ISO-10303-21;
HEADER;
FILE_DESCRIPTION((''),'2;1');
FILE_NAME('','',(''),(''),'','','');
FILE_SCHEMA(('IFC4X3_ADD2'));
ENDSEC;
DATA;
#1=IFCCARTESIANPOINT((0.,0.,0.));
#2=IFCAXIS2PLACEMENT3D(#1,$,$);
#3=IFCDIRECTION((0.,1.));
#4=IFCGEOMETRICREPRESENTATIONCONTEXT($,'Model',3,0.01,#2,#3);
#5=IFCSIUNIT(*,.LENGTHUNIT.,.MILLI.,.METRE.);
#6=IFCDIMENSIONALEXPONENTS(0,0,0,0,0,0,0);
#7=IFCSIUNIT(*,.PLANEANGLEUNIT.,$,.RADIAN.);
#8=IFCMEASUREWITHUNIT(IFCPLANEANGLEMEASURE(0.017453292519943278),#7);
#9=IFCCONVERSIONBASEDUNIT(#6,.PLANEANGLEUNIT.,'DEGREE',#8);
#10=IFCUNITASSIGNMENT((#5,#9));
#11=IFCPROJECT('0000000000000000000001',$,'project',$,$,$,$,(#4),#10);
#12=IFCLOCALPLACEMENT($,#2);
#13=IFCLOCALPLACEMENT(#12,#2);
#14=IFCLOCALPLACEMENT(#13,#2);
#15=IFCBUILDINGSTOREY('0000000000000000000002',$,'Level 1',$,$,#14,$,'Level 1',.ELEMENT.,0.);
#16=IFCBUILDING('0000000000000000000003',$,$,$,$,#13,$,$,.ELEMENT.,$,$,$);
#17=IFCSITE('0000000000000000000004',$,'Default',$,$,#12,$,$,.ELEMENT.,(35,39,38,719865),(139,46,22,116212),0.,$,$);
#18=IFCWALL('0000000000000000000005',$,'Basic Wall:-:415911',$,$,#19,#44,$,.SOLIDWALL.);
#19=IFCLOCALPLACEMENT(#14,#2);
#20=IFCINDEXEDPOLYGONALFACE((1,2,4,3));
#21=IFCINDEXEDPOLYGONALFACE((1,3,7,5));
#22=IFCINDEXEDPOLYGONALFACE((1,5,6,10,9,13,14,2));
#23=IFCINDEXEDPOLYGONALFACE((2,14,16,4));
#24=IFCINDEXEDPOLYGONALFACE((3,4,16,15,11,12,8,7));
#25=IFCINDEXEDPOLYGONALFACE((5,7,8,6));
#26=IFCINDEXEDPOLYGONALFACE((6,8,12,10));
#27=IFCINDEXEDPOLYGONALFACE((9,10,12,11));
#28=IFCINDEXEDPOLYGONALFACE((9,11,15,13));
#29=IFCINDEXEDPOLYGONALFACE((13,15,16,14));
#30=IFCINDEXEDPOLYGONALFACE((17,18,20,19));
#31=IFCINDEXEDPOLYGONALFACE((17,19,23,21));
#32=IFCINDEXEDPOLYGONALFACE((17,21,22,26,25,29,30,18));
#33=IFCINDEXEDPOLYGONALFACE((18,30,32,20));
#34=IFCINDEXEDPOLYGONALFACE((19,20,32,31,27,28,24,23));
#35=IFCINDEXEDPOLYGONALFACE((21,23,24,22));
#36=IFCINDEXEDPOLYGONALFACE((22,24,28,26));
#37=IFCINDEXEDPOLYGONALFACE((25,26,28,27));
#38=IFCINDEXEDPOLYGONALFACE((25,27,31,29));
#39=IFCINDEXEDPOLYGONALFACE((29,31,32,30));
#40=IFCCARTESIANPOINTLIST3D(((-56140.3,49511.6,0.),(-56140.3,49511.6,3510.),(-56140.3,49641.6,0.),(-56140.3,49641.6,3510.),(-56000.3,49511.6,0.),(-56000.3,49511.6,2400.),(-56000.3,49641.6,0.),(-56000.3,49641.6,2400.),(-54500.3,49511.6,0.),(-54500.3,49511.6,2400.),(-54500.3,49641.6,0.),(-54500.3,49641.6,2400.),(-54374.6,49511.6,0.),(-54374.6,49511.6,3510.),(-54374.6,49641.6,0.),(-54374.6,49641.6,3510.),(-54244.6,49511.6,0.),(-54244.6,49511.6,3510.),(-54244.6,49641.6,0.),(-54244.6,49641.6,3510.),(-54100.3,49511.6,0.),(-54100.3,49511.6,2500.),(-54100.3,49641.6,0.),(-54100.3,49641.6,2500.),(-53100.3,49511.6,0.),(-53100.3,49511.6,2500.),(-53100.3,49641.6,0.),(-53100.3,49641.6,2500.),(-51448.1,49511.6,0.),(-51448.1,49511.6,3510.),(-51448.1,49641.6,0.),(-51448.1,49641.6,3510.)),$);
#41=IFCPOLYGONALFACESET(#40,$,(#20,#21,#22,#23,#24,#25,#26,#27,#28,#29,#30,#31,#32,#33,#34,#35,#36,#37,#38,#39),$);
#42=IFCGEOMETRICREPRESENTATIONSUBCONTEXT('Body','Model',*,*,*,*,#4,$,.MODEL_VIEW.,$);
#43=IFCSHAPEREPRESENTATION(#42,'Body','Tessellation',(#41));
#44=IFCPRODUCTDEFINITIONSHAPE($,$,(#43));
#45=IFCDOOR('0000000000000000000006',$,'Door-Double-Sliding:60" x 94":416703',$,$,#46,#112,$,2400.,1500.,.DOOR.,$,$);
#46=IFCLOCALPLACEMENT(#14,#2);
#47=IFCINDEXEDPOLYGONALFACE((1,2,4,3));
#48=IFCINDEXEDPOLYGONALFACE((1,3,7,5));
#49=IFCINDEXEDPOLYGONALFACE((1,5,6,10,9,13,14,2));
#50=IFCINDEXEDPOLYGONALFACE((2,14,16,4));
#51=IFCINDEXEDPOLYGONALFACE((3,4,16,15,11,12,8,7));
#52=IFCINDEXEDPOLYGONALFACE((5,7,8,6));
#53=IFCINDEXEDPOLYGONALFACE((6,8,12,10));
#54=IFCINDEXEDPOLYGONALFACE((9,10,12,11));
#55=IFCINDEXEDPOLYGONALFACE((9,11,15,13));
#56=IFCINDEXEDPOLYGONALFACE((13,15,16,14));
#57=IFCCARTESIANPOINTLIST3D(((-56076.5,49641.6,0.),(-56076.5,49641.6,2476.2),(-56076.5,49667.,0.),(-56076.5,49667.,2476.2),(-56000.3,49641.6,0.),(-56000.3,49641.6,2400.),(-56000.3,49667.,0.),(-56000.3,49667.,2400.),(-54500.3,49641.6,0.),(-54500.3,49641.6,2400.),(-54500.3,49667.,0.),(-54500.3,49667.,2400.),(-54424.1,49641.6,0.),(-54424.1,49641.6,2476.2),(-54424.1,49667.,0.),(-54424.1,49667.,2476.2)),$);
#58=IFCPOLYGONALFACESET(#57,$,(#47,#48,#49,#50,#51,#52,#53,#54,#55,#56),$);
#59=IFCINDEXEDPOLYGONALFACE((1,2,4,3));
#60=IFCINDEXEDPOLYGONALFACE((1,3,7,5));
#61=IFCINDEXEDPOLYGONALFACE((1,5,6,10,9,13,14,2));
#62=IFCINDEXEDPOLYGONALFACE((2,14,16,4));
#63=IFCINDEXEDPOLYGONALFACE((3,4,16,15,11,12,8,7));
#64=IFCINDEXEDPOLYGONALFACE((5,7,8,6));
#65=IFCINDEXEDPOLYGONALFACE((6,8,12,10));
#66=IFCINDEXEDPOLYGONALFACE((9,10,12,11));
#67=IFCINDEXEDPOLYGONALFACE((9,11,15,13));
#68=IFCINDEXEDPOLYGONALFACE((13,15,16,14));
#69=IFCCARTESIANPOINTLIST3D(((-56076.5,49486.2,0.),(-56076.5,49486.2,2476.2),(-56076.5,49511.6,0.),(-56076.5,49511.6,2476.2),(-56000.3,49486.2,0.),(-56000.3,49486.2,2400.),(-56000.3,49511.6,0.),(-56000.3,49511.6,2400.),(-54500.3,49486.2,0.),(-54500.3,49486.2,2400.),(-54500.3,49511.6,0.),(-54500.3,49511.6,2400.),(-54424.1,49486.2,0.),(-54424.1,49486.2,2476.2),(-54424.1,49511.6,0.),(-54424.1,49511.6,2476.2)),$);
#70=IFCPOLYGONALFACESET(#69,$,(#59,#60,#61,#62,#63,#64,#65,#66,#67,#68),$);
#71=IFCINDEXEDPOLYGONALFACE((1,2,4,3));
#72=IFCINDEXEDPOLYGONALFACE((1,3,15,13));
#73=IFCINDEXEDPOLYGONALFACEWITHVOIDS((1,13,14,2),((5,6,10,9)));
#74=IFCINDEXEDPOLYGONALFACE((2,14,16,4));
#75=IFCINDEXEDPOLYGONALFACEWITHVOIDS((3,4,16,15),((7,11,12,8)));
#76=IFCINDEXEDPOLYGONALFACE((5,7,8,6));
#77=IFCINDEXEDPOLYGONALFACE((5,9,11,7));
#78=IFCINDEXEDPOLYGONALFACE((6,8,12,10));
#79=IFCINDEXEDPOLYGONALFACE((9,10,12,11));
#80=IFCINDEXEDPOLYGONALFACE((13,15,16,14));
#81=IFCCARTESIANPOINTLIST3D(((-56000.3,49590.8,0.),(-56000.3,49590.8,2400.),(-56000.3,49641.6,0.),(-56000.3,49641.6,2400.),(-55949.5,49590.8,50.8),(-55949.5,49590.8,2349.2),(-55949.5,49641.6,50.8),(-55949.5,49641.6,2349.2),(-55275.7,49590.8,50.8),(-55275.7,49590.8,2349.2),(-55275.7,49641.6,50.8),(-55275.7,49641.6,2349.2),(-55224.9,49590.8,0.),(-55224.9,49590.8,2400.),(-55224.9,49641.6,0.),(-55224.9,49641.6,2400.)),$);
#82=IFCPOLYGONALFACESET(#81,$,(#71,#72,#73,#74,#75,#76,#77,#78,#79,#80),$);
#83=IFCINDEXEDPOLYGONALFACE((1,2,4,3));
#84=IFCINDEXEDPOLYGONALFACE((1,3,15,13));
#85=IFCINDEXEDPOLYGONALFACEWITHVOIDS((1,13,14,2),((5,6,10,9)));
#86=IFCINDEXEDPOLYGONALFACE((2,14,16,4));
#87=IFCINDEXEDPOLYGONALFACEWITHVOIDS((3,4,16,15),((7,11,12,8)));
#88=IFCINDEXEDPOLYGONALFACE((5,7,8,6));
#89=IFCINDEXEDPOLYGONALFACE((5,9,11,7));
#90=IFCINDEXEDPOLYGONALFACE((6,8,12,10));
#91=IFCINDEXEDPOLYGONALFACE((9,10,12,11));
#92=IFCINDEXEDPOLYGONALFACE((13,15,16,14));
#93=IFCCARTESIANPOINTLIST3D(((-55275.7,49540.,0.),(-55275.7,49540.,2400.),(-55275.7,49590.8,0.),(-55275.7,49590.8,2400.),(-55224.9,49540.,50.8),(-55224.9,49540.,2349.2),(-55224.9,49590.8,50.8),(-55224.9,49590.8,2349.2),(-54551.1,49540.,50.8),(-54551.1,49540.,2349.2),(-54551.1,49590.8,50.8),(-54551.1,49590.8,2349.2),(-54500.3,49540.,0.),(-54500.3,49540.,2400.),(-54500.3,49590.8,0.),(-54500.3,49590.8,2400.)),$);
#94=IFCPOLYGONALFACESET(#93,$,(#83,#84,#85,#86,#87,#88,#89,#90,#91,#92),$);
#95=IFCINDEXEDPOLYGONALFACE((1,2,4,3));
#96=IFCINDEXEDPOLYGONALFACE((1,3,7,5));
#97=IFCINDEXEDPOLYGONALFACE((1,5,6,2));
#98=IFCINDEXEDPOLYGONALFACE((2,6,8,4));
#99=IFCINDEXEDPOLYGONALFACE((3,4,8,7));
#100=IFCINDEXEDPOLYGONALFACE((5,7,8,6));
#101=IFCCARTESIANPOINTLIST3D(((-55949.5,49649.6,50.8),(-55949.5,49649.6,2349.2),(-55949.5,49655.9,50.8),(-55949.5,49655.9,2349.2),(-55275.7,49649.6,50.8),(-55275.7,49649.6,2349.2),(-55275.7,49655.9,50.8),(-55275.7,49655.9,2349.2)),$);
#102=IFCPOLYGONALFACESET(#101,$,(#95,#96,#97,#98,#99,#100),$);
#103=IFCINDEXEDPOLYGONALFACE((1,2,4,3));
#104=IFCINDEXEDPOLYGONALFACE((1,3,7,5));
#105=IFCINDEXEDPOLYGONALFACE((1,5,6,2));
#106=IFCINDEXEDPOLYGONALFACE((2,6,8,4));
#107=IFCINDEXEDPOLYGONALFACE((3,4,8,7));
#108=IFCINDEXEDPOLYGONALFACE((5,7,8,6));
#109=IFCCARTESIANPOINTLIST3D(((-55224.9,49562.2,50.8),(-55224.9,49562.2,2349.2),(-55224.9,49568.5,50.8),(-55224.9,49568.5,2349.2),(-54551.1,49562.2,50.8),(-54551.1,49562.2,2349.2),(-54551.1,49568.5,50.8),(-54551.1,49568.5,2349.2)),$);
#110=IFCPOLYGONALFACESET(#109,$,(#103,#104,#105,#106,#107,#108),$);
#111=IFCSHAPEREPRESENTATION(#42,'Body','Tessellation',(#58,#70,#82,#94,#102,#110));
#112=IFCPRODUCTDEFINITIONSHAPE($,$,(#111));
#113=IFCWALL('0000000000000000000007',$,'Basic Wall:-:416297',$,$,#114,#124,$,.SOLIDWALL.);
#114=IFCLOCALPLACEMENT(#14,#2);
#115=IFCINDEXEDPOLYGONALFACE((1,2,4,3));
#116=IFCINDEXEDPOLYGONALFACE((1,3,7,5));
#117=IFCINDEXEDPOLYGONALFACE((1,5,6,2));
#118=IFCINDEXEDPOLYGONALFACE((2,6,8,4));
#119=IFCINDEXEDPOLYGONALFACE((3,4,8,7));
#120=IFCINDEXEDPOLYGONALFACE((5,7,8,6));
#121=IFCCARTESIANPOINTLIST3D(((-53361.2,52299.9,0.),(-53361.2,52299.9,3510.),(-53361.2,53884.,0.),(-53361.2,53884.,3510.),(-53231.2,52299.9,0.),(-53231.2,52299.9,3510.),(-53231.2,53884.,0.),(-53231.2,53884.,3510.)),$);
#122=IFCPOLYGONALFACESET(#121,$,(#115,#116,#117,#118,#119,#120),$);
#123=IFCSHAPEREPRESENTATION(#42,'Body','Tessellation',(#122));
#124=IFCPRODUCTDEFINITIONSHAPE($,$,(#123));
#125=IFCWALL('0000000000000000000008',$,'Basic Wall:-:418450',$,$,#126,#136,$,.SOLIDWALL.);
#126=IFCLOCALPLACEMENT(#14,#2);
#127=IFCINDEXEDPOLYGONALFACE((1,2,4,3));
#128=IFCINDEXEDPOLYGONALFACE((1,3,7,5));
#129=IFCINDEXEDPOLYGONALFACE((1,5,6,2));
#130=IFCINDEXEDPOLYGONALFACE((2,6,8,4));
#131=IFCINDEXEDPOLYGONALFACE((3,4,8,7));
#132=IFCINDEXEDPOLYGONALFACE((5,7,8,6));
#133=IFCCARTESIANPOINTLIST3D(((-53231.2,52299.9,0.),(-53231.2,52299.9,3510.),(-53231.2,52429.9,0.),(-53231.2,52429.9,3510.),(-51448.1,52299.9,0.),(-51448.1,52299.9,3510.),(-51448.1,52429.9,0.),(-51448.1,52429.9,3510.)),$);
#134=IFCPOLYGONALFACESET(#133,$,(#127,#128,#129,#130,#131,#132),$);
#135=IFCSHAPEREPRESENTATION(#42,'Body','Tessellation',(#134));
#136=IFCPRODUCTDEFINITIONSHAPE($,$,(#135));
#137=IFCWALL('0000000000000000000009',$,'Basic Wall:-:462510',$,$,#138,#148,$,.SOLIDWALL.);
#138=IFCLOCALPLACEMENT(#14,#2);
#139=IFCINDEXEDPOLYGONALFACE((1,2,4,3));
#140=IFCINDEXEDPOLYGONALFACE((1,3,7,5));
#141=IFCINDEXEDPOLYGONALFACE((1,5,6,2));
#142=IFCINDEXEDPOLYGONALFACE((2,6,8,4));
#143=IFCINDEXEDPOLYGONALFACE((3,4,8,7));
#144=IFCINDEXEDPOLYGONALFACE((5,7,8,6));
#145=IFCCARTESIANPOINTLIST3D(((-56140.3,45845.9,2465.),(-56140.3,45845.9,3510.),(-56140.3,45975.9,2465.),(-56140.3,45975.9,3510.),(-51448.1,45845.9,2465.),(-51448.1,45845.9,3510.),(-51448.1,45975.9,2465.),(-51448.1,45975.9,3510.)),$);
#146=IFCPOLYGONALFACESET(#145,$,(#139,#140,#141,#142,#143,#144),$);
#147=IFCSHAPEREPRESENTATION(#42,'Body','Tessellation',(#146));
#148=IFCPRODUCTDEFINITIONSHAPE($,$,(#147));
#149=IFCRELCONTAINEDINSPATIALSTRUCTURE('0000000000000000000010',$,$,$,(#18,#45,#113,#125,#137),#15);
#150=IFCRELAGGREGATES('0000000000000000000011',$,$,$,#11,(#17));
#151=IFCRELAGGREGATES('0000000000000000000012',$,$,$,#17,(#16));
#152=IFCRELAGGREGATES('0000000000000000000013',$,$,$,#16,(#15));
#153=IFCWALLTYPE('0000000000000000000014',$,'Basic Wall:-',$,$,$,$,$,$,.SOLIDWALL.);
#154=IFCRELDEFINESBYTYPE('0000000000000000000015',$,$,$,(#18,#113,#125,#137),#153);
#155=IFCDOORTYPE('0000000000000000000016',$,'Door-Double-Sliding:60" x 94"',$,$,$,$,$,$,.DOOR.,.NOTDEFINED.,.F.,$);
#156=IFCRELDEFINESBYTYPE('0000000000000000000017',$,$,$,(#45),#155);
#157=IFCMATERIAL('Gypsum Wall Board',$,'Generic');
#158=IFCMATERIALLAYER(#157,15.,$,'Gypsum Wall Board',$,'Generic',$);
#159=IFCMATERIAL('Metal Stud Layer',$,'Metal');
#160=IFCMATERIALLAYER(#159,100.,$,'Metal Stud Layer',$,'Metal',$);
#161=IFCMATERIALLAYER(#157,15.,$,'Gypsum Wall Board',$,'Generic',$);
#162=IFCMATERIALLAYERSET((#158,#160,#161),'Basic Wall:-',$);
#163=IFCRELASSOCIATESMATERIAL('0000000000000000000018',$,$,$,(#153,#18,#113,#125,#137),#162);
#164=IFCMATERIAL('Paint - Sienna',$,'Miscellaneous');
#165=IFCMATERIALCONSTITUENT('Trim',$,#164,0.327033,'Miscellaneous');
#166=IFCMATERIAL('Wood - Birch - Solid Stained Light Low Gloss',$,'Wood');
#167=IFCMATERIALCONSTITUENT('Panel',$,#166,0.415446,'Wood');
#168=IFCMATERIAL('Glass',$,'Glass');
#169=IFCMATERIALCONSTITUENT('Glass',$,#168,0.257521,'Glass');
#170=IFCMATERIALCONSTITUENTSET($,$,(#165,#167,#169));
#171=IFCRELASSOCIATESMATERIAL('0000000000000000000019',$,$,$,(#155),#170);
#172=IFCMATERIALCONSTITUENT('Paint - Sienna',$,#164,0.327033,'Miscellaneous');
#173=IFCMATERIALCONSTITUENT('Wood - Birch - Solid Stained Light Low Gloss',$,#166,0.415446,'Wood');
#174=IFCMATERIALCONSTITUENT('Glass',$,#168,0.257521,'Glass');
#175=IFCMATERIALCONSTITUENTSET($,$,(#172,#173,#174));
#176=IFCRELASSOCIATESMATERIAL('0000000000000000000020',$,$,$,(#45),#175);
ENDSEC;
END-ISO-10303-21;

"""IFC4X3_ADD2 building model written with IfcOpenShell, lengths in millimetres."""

from ifc_helpers import new_model, entity, si_unit, converted_unit, direction, frame, frame_2d, origin, origin_2d_with_axis, place, context, subcontext, project, spatial, polyline, rectangle, outline, extrude, source, transform, mapped, material, layer, layer_set, constituent, constituent_set, type_object, type_shapes, element, fill, save


model = new_model("IFC4X3_ADD2")

# Units and contexts
model_context = context("Model", 3, precision=0.01, world=origin(), true_north=direction((0.0, 1.0)))
body_context = subcontext(model_context, "Body", "Model", "MODEL_VIEW")
ifc_project = project(units=[si_unit("LENGTHUNIT", "METRE", prefix="MILLI"), converted_unit("PLANEANGLEUNIT", "DEGREE", entity("IfcPlaneAngleMeasure", 0.017453292519943278), si_unit("PLANEANGLEUNIT", "RADIAN"), dimensions=[0, 0, 0, 0, 0, 0, 0])], contexts=[model_context])

# Site, building, storey
site_placement = place(None, origin())
site = spatial("IfcSite", under=ifc_project, at=site_placement, Name="Default", CompositionType="ELEMENT", RefLatitude=(35, 39, 38, 719865), RefLongitude=(139, 46, 22, 116212), RefElevation=0.0)
building_placement = place(site_placement, origin())
building = spatial("IfcBuilding", under=site, at=building_placement, CompositionType="ELEMENT")
storey_placement = place(building_placement, origin())
storey = spatial("IfcBuildingStorey", under=building, at=storey_placement, Name="Level 1", LongName="Level 1", CompositionType="ELEMENT", Elevation=0.0)

# Shared definitions
ifc_material_1 = material(Name="Glass", Category="Glass")

# Wall, openings, door
ifc_material_2 = material(Name="Gypsum Wall Board", Category="Generic")
ifc_layer_1 = layer(ifc_material_2, 15.0, Name="Gypsum Wall Board", Category="Generic")
ifc_material_3 = material(Name="Metal Stud Layer", Category="Metal")
ifc_layer_2 = layer(ifc_material_3, 100.0, Name="Metal Stud Layer", Category="Metal")
ifc_layer_3 = layer(ifc_material_2, 15.0, Name="Gypsum Wall Board", Category="Generic")
ifc_layer_set_1 = layer_set([ifc_layer_1, ifc_layer_2, ifc_layer_3], Name="Basic Wall:-")
wall_type = type_object("IfcWallType", Name="Basic Wall:-", PredefinedType="SOLIDWALL", material=ifc_layer_set_1)
wall_1_placement = place(storey_placement, frame((-51448.1, 49576.6, 0.0), z_axis=(0.0, 0.0, 1.0), x_axis=(-1.0, 0.0, 0.0)))
wall_1 = element("IfcWall", 1, at=wall_1_placement, inside=storey, type_object=wall_type, material=ifc_layer_set_1, Name="Basic Wall:-:415911", PredefinedType="SOLIDWALL", context=body_context, shape_type="SweptSolid", body=[
    extrude(rectangle(XDim=4692.1, YDim=130.0, at=frame_2d((2346.1, 0.0), x_axis=(-1.0, 0.0))), origin(), (0.0, 0.0, 1.0), 3510.0),
])
opening_1_placement = place(storey_placement, frame((-51448.1, 49576.6, 0.0), z_axis=(0.0, 0.0, 1.0), x_axis=(-1.0, 0.0, 0.0)))
element("IfcOpeningElement", 2, at=opening_1_placement, cuts=wall_1, PredefinedType="OPENING", context=body_context, shape_type="SweptSolid", body=[
    extrude(rectangle(XDim=3510.0, YDim=130.0, at=frame_2d((0.0, 0.0), x_axis=(1.0, 0.0))), frame((2926.4, 0.0, 1755.0), z_axis=(-1.0, 0.0, 0.0), x_axis=(0.0, 0.0, 1.0)), (0.0, 0.0, 1.0), 130.0),
])
opening_2_placement = place(wall_1_placement, frame((4552.1, 65.0, 0.0)))
opening_2 = element("IfcOpeningElement", 3, at=opening_2_placement, cuts=wall_1, PredefinedType="OPENING", context=body_context, shape_type="SweptSolid", body=[
    extrude(rectangle(XDim=2400.0, YDim=1500.0, at=frame_2d((1200.0, 750.0), x_axis=(-1.0, 0.0))), frame((0.0, 0.0, 0.0), z_axis=(0.0, -1.0, 0.0), x_axis=(0.0, 0.0, 1.0)), (0.0, 0.0, 1.0), 130.0),
])
opening_3_placement = place(wall_1_placement, frame((2652.1, 65.0, 0.0)))
element("IfcOpeningElement", 4, at=opening_3_placement, cuts=wall_1, PredefinedType="OPENING", context=body_context, shape_type="SweptSolid", body=[
    extrude(rectangle(XDim=2500.0, YDim=1000.0, at=frame_2d((1250.0, 500.0), x_axis=(1.0, 0.0))), frame((0.0, 0.0, 0.0), z_axis=(0.0, -1.0, 0.0), x_axis=(0.0, 0.0, 1.0)), (0.0, 0.0, 1.0), 130.0),
])
ifc_material_4 = material(Name="Paint - Sienna", Category="Miscellaneous")
ifc_constituent_1 = constituent(ifc_material_4, Name="Paint - Sienna", Category="Miscellaneous", fraction=0.327033)
ifc_material_5 = material(Name="Wood - Birch - Solid Stained Light Low Gloss", Category="Wood")
ifc_constituent_2 = constituent(ifc_material_5, Name="Wood - Birch - Solid Stained Light Low Gloss", Category="Wood", fraction=0.415446)
ifc_constituent_3 = constituent(ifc_material_1, Name="Glass", Category="Glass", fraction=0.257521)
ifc_constituent_set_1 = constituent_set(constituents=[ifc_constituent_1, ifc_constituent_2, ifc_constituent_3])
ifc_constituent_4 = constituent(ifc_material_4, Name="Trim", Category="Miscellaneous", fraction=0.327033)
ifc_constituent_5 = constituent(ifc_material_5, Name="Panel", Category="Wood", fraction=0.415446)
ifc_constituent_6 = constituent(ifc_material_1, Name="Glass", Category="Glass", fraction=0.257521)
ifc_constituent_set_2 = constituent_set(constituents=[ifc_constituent_4, ifc_constituent_5, ifc_constituent_6])
door_type_1 = type_object("IfcDoorType", Name="Door-Double-Sliding:60\" x 94\"", OperationType="NOTDEFINED", ParameterTakesPrecedence=False, PredefinedType="DOOR", material=ifc_constituent_set_2)
shared_shape_1 = source(origin(), body_context, "Body", "SweptSolid", [
    extrude(outline(polyline([(-826.2, -1219.0), (-750.0, -1219.0), (-750.0, 1181.0), (750.0, 1180.9), (750.0, -1219.1), (826.2, -1219.1), (826.2, 1257.1), (-826.2, 1257.1), (-826.2, -1219.0)])), frame((750.0, 130.0, 1219.0), z_axis=(0.0, 1.0, 0.0), x_axis=(-1.0, 0.0, 0.0)), (0.0, 0.0, 1.0), 25.4),
    extrude(outline(polyline([(-1219.0, -826.2), (1257.1, -826.2), (1257.1, 826.2), (-1219.0, 826.2), (-1219.0, 750.0), (1180.9, 750.0), (1180.9, -750.0), (-1219.0, -750.0), (-1219.0, -826.2)])), frame((750.0, -25.4, 1219.0), z_axis=(0.0, 1.0, 0.0), x_axis=(0.0, 0.0, 1.0)), (0.0, 0.0, 1.0), 25.4),
    extrude(outline(polyline([(-1200.0, -387.7), (1200.0, -387.7), (1200.0, 387.7), (-1200.0, 387.7), (-1200.0, -387.7)]), holes=[polyline([(-1149.2, -336.9), (-1149.2, 336.9), (1149.2, 336.9), (1149.2, -336.9), (-1149.2, -336.9)])]), frame((387.7, 79.2, 1200.0), z_axis=(0.0, 1.0, 0.0), x_axis=(0.0, 0.0, -1.0)), (0.0, 0.0, 1.0), 50.8),
    extrude(outline(polyline([(-387.7, -1200.0), (387.7, -1200.0), (387.7, 1200.0), (-387.7, 1200.0), (-387.7, -1200.0)]), holes=[polyline([(-336.9, -1149.2), (-336.9, 1149.2), (336.9, 1149.2), (336.9, -1149.2), (-336.9, -1149.2)])]), frame((1112.3, 28.4, 1200.0), z_axis=(0.0, 1.0, 0.0), x_axis=(1.0, 0.0, 0.0)), (0.0, 0.0, 1.0), 50.8),
    extrude(rectangle(XDim=6.4, YDim=673.8, at=origin_2d_with_axis()), frame((387.7, 141.2, 50.8), z_axis=(0.0, 0.0, 1.0), x_axis=(0.0, 1.0, 0.0)), (0.0, 0.0, 1.0), 2298.4),
    extrude(rectangle(XDim=6.3, YDim=673.8, at=frame_2d((0.0, 0.0), x_axis=(1.0, 0.0))), frame((1112.3, 53.8, 50.8), z_axis=(0.0, 0.0, 1.0), x_axis=(0.0, -1.0, 0.0)), (0.0, 0.0, 1.0), 2298.4),
])
type_shapes(door_type_1, [shared_shape_1])
door_1_placement = place(opening_2_placement, frame((0.0, 0.0, 0.0), z_axis=(0.0, 0.0, 1.0), x_axis=(-1.0, 0.0, 0.0)))
door_1 = element("IfcDoor", 5, at=door_1_placement, inside=storey, type_object=door_type_1, material=ifc_constituent_set_1, Name="Door-Double-Sliding:60\" x 94\":416703", OverallHeight=2400.0, OverallWidth=1500.0, PredefinedType="DOOR", context=body_context, shape_type="MappedRepresentation", body=[
    mapped(shared_shape_1, transform((0.0, 0.0, 0.0), scale=1.0)),
])
fill(opening_2, door_1)

# Walls
wall_2_placement = place(storey_placement, frame((-53296.2, 52299.9, 0.0), z_axis=(0.0, 0.0, 1.0), x_axis=(0.0, 1.0, 0.0)))
element("IfcWall", 6, at=wall_2_placement, inside=storey, type_object=wall_type, material=ifc_layer_set_1, Name="Basic Wall:-:416297", PredefinedType="SOLIDWALL", context=body_context, shape_type="SweptSolid", body=[
    extrude(rectangle(XDim=1584.2, YDim=130.0, at=frame_2d((792.1, 0.0), x_axis=(-1.0, 0.0))), origin(), (0.0, 0.0, 1.0), 3510.0),
])
wall_3_placement = place(storey_placement, frame((-51448.1, 52364.9, 0.0), z_axis=(0.0, 0.0, 1.0), x_axis=(-1.0, 0.0, 0.0)))
element("IfcWall", 7, at=wall_3_placement, inside=storey, type_object=wall_type, material=ifc_layer_set_1, Name="Basic Wall:-:418450", PredefinedType="SOLIDWALL", context=body_context, shape_type="SweptSolid", body=[
    extrude(rectangle(XDim=1783.1, YDim=130.0, at=frame_2d((891.5, 0.0), x_axis=(-1.0, 0.0))), origin(), (0.0, 0.0, 1.0), 3510.0),
])
wall_4_placement = place(storey_placement, frame((-51448.1, 45910.9, 2465.0), z_axis=(0.0, 0.0, 1.0), x_axis=(-1.0, 0.0, 0.0)))
element("IfcWall", 8, at=wall_4_placement, inside=storey, type_object=wall_type, material=ifc_layer_set_1, Name="Basic Wall:-:462510", PredefinedType="SOLIDWALL", context=body_context, shape_type="SweptSolid", body=[
    extrude(rectangle(XDim=4692.1, YDim=130.0, at=frame_2d((2346.1, 0.0), x_axis=(-1.0, 0.0))), origin(), (0.0, 0.0, 1.0), 1045.0),
])

save(model, "model.ifc")
